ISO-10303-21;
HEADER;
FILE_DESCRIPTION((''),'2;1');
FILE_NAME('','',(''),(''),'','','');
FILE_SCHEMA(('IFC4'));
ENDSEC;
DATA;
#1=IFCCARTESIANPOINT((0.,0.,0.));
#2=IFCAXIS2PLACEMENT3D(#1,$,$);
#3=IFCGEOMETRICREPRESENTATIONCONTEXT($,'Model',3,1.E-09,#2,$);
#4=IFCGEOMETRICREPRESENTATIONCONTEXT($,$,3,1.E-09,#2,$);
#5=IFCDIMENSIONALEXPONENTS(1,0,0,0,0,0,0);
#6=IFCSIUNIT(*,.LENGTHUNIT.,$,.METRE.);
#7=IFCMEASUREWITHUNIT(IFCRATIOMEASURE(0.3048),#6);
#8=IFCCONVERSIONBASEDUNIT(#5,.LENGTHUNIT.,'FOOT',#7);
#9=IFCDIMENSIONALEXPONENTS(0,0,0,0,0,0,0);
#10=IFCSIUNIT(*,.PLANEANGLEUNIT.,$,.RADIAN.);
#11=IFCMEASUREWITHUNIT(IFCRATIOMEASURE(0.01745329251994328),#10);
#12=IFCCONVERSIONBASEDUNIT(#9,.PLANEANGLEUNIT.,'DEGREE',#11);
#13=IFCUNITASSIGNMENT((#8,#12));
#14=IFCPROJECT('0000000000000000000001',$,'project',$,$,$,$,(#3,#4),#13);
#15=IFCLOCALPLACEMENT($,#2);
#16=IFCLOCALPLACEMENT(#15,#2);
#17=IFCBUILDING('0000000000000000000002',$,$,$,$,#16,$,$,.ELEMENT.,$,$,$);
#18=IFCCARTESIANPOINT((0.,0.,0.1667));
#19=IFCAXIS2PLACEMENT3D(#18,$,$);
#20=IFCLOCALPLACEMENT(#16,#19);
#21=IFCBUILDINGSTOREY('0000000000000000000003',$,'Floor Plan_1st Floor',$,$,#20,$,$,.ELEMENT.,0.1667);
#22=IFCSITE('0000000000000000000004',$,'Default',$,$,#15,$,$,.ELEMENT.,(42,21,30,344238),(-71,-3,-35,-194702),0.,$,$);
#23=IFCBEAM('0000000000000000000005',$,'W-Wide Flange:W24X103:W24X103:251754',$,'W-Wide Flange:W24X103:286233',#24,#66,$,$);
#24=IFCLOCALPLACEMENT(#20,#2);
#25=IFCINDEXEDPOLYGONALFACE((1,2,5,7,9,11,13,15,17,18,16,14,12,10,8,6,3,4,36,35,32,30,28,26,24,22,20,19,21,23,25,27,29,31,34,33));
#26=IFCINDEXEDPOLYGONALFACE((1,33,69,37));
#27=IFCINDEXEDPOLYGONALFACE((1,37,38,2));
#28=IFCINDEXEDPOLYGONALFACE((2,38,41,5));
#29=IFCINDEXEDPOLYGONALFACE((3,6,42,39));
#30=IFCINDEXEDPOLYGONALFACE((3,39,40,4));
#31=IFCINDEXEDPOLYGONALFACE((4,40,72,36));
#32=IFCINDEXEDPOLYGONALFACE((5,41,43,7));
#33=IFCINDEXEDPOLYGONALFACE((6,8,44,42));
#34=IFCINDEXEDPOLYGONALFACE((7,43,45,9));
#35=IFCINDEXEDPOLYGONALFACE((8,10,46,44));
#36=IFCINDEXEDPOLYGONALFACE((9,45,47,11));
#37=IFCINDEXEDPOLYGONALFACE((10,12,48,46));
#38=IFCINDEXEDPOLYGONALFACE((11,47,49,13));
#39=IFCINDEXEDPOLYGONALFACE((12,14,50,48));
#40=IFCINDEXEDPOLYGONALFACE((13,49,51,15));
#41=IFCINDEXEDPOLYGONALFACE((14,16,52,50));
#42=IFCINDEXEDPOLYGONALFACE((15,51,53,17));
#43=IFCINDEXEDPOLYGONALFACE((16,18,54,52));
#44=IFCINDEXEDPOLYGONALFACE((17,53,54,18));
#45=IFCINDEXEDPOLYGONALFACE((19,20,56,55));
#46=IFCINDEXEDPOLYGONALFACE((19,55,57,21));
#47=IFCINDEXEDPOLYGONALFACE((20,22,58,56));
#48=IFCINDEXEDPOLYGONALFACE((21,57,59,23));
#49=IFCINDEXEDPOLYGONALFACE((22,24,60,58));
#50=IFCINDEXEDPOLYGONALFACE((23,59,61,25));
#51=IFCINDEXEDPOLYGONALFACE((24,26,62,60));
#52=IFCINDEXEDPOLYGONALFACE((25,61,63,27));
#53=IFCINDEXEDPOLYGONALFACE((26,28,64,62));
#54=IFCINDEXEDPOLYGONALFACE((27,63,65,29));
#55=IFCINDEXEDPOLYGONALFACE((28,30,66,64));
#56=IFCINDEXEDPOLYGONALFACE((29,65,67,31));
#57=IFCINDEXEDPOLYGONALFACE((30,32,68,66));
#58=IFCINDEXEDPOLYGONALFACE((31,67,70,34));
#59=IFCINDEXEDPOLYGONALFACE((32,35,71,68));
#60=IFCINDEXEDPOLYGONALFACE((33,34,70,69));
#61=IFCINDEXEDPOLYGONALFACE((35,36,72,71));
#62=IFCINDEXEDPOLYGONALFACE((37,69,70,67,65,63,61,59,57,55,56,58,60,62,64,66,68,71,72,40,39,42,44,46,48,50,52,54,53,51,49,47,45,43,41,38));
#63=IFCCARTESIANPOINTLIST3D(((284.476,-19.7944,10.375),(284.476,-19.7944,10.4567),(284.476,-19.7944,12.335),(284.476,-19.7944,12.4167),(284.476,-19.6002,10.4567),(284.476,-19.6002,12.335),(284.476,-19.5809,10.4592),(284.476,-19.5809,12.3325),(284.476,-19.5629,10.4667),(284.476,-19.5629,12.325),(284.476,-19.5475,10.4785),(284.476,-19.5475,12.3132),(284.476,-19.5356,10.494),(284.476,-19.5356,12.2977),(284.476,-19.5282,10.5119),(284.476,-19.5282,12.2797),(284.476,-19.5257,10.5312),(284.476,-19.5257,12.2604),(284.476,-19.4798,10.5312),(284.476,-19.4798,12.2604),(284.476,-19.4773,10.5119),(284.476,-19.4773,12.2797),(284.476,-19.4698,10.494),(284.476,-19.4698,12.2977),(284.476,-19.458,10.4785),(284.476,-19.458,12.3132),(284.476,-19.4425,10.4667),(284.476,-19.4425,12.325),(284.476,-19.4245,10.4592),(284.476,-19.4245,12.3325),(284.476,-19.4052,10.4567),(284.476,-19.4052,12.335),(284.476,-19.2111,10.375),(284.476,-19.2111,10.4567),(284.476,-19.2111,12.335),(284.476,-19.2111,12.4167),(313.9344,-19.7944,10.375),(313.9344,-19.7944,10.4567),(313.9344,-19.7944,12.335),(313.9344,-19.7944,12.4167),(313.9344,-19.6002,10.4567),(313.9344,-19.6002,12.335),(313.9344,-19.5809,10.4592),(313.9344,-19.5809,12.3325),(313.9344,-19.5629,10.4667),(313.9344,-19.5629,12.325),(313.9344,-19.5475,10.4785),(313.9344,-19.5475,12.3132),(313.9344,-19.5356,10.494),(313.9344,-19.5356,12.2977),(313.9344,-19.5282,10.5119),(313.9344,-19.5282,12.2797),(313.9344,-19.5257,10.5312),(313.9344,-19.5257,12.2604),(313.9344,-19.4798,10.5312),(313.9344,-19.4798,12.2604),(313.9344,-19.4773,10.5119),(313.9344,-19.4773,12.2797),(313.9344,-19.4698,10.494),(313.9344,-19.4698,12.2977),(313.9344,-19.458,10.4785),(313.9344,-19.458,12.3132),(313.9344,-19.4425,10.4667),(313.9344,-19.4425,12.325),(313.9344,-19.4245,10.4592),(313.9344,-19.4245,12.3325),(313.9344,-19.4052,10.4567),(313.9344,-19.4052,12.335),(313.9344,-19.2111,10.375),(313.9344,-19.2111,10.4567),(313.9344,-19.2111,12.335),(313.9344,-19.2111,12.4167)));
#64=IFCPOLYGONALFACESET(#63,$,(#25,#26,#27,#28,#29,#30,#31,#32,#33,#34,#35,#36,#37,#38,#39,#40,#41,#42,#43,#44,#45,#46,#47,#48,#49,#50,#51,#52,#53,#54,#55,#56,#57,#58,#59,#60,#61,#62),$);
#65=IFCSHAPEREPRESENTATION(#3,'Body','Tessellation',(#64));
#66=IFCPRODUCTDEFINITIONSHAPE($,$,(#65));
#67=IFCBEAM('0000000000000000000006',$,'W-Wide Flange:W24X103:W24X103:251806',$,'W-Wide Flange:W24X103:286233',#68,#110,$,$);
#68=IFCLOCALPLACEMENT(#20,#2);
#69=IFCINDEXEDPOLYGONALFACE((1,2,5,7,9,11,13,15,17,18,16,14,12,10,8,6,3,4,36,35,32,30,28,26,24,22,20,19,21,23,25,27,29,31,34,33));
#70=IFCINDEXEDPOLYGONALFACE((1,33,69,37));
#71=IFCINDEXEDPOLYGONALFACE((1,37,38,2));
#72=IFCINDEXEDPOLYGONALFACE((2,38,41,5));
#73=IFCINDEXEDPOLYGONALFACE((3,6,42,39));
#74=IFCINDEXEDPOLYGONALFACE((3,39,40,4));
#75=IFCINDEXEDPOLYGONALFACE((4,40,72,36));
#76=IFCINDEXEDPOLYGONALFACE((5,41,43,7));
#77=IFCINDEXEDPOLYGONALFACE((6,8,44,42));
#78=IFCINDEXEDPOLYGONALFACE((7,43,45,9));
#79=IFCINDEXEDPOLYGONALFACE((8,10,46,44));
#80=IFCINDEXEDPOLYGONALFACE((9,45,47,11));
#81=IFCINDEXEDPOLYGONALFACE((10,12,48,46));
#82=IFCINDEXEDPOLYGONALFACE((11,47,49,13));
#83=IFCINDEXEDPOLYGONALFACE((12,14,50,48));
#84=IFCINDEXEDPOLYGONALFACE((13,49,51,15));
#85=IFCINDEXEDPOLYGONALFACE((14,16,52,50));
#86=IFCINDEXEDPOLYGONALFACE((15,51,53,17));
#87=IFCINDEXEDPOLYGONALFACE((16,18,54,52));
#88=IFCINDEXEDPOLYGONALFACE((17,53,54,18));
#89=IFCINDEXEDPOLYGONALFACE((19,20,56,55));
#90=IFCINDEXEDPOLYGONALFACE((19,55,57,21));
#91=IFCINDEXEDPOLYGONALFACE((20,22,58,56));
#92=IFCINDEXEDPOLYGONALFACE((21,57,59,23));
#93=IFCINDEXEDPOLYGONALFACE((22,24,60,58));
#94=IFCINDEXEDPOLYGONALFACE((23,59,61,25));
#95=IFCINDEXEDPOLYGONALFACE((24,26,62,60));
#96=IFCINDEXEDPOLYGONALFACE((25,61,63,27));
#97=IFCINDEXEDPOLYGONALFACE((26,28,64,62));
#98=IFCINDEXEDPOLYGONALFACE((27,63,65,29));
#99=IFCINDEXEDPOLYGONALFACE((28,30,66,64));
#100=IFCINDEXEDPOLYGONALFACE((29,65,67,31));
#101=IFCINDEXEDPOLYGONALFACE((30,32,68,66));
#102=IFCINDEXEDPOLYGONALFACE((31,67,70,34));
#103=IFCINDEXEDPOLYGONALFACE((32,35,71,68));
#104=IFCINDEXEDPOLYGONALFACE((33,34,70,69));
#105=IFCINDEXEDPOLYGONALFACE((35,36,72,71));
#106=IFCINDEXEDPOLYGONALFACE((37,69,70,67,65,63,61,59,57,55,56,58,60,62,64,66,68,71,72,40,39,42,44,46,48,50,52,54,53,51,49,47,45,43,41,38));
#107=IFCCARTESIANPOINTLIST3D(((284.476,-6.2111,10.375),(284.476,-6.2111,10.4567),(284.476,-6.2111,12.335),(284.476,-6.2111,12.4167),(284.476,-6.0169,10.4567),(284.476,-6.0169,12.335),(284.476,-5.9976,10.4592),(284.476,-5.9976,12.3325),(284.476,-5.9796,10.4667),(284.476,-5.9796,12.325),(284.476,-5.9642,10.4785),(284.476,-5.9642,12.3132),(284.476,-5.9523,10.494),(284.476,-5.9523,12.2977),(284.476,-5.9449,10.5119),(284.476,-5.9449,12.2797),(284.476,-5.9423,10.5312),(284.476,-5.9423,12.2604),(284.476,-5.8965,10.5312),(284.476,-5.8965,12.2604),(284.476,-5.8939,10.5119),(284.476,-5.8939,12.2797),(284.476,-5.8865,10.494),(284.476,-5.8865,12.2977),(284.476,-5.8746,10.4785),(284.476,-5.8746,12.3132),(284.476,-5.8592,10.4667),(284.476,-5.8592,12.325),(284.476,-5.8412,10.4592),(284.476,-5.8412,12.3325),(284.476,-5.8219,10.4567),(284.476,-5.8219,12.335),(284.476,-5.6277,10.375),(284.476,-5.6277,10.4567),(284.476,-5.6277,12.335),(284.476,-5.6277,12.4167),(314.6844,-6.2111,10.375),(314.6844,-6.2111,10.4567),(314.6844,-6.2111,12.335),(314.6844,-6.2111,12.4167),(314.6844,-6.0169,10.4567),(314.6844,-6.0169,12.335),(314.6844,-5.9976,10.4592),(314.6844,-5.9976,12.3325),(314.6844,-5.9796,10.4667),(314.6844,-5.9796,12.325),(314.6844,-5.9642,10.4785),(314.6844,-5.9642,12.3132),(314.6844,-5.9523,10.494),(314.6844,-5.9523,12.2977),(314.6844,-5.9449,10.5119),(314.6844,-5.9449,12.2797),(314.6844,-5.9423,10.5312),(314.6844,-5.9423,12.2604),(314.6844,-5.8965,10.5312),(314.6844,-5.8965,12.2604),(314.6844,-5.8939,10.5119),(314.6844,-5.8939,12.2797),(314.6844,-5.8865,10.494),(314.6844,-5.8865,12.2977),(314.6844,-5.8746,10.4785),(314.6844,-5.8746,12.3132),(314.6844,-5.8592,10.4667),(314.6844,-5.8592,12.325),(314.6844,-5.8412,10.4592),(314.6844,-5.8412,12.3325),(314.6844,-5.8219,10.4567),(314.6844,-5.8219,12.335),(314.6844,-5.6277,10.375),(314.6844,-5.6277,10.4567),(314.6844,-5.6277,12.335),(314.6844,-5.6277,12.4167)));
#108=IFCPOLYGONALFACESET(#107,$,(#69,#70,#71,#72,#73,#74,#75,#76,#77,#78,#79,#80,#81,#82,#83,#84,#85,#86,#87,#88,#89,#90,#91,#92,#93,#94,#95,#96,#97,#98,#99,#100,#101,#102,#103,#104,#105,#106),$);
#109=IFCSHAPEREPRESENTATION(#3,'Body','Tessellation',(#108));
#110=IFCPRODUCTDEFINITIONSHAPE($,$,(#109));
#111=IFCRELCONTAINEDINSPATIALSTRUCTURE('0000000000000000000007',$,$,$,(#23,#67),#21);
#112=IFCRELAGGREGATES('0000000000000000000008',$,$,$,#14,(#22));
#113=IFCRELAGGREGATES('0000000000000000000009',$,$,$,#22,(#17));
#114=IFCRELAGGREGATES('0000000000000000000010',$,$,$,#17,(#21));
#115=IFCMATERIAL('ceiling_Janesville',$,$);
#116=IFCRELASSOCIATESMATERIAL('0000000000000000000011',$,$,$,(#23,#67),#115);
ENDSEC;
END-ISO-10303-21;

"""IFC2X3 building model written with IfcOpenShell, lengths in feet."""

from ifc_helpers import new_model, entity, si_unit, converted_unit, frame, frame_2d, origin, place, context, project, spatial, polyline, circle_curve, parameter, trimmed, segment, composite_curve, outline, extrude, material, element, save


model = new_model("IFC2X3")

# Units and contexts
model_context = context("Model", 3, precision=1e-09, world=origin())
context_of_model = context(None, 3, precision=1e-09, world=origin())
ifc_project = project(units=[converted_unit("LENGTHUNIT", "FOOT", entity("IfcRatioMeasure", 0.3048), si_unit("LENGTHUNIT", "METRE"), dimensions=[1, 0, 0, 0, 0, 0, 0]), converted_unit("PLANEANGLEUNIT", "DEGREE", entity("IfcRatioMeasure", 0.01745329251994328), si_unit("PLANEANGLEUNIT", "RADIAN"), dimensions=[0, 0, 0, 0, 0, 0, 0])], contexts=[model_context, context_of_model])

# Site, building, storey
site_placement = place(None, origin())
site = spatial("IfcSite", under=ifc_project, at=site_placement, Name="Default", CompositionType="ELEMENT", RefLatitude=(42, 21, 30, 344238), RefLongitude=(-71, -3, -35, -194702), RefElevation=0.0)
building_placement = place(site_placement, origin())
building = spatial("IfcBuilding", under=site, at=building_placement, CompositionType="ELEMENT")
storey_placement = place(building_placement, frame((0.0, 0.0, 0.1667)))
storey = spatial("IfcBuildingStorey", under=building, at=storey_placement, Name="Floor Plan_1st Floor", CompositionType="ELEMENT", Elevation=0.1667)

# Beams
ifc_material = material(Name="ceiling_Janesville")
beam_1_placement = place(storey_placement, frame((284.4763, -19.5027, 12.4167), z_axis=(0.0, 0.0, 1.0), x_axis=(0.0, -1.0, 0.0)))
element("IfcBeam", 1, at=beam_1_placement, inside=storey, material=ifc_material, Name="W-Wide Flange:W24X103:W24X103:251754", ObjectType="W-Wide Flange:W24X103:286233", context=model_context, shape_type="SweptSolid", body=[
    extrude(outline(composite_curve([segment(polyline([(-0.2917, -0.9392), (-0.2917, -1.0208)]), True, "CONTINUOUS"), segment(polyline([(-0.2917, -1.0208), (0.2917, -1.0208)]), True, "CONTINUOUS"), segment(polyline([(0.2917, -1.0208), (0.2917, -0.9392)]), True, "CONTINUOUS"), segment(polyline([(0.2917, -0.9392), (0.0975, -0.9392)]), True, "CONTINUOUS"), segment(trimmed(circle_curve(frame_2d((0.0975, -0.8646), x_axis=(1.0, 0.0)), 0.0746), [parameter(180.0)], [parameter(270.0)], True, "PARAMETER"), False, "CONTINUOUS"), segment(polyline([(0.0229, -0.8646), (0.0229, 0.8646)]), True, "CONTINUOUS"), segment(trimmed(circle_curve(frame_2d((0.0975, 0.8646), x_axis=(1.0, 0.0)), 0.0746), [parameter(90.0)], [parameter(180.0)], True, "PARAMETER"), False, "CONTINUOUS"), segment(polyline([(0.0975, 0.9392), (0.2917, 0.9392)]), True, "CONTINUOUS"), segment(polyline([(0.2917, 0.9392), (0.2917, 1.0208)]), True, "CONTINUOUS"), segment(polyline([(0.2917, 1.0208), (-0.2917, 1.0208)]), True, "CONTINUOUS"), segment(polyline([(-0.2917, 1.0208), (-0.2917, 0.9392)]), True, "CONTINUOUS"), segment(polyline([(-0.2917, 0.9392), (-0.0975, 0.9392)]), True, "CONTINUOUS"), segment(trimmed(circle_curve(frame_2d((-0.0975, 0.8646), x_axis=(1.0, 0.0)), 0.0746), [parameter(360.0)], [parameter(90.0)], True, "PARAMETER"), False, "CONTINUOUS"), segment(polyline([(-0.0229, 0.8646), (-0.0229, -0.8646)]), True, "CONTINUOUS"), segment(trimmed(circle_curve(frame_2d((-0.0975, -0.8646), x_axis=(1.0, 0.0)), 0.0746), [parameter(270.0)], [parameter(360.0)], True, "PARAMETER"), False, "CONTINUOUS"), segment(polyline([(-0.0975, -0.9392), (-0.2917, -0.9392)]), True, "CONTINUOUS")], self_intersect=False)), frame((0.0, -0.0003, -1.0208), z_axis=(0.0, -1.0, 0.0), x_axis=(1.0, 0.0, 0.0)), (0.0, 0.0, -1.0), 29.4583),
])
beam_2_placement = place(storey_placement, frame((286.6846, -5.9194, 12.4167), z_axis=(0.0, 0.0, 1.0), x_axis=(0.0, -1.0, 0.0)))
element("IfcBeam", 2, at=beam_2_placement, inside=storey, material=ifc_material, Name="W-Wide Flange:W24X103:W24X103:251806", ObjectType="W-Wide Flange:W24X103:286233", context=model_context, shape_type="SweptSolid", body=[
    extrude(outline(composite_curve([segment(polyline([(-0.2917, -0.9392), (-0.2917, -1.0208)]), True, "CONTINUOUS"), segment(polyline([(-0.2917, -1.0208), (0.2917, -1.0208)]), True, "CONTINUOUS"), segment(polyline([(0.2917, -1.0208), (0.2917, -0.9392)]), True, "CONTINUOUS"), segment(polyline([(0.2917, -0.9392), (0.0975, -0.9392)]), True, "CONTINUOUS"), segment(trimmed(circle_curve(frame_2d((0.0975, -0.8646), x_axis=(0.0, -1.0)), 0.0746), [parameter(270.0)], [parameter(360.0)], True, "PARAMETER"), False, "CONTINUOUS"), segment(polyline([(0.0229, -0.8646), (0.0229, 0.8646)]), True, "CONTINUOUS"), segment(trimmed(circle_curve(frame_2d((0.0975, 0.8646), x_axis=(-1.0, 0.0)), 0.0746), [parameter(270.0)], [parameter(0.0)], True, "PARAMETER"), False, "CONTINUOUS"), segment(polyline([(0.0975, 0.9392), (0.2917, 0.9392)]), True, "CONTINUOUS"), segment(polyline([(0.2917, 0.9392), (0.2917, 1.0208)]), True, "CONTINUOUS"), segment(polyline([(0.2917, 1.0208), (-0.2917, 1.0208)]), True, "CONTINUOUS"), segment(polyline([(-0.2917, 1.0208), (-0.2917, 0.9392)]), True, "CONTINUOUS"), segment(polyline([(-0.2917, 0.9392), (-0.0975, 0.9392)]), True, "CONTINUOUS"), segment(trimmed(circle_curve(frame_2d((-0.0975, 0.8646), x_axis=(0.0, 1.0)), 0.0746), [parameter(270.0)], [parameter(0.0)], True, "PARAMETER"), False, "CONTINUOUS"), segment(polyline([(-0.0229, 0.8646), (-0.0229, -0.8646)]), True, "CONTINUOUS"), segment(trimmed(circle_curve(frame_2d((-0.0975, -0.8646), x_axis=(1.0, 0.0)), 0.0746), [parameter(270.0)], [parameter(0.0)], True, "PARAMETER"), False, "CONTINUOUS"), segment(polyline([(-0.0975, -0.9392), (-0.2917, -0.9392)]), True, "CONTINUOUS")], self_intersect=False)), frame((0.0, -2.2086, -1.0208), z_axis=(0.0, -1.0, 0.0), x_axis=(1.0, 0.0, 0.0)), (0.0, 0.0, -1.0), 30.2083),
])

save(model, "model.ifc")
